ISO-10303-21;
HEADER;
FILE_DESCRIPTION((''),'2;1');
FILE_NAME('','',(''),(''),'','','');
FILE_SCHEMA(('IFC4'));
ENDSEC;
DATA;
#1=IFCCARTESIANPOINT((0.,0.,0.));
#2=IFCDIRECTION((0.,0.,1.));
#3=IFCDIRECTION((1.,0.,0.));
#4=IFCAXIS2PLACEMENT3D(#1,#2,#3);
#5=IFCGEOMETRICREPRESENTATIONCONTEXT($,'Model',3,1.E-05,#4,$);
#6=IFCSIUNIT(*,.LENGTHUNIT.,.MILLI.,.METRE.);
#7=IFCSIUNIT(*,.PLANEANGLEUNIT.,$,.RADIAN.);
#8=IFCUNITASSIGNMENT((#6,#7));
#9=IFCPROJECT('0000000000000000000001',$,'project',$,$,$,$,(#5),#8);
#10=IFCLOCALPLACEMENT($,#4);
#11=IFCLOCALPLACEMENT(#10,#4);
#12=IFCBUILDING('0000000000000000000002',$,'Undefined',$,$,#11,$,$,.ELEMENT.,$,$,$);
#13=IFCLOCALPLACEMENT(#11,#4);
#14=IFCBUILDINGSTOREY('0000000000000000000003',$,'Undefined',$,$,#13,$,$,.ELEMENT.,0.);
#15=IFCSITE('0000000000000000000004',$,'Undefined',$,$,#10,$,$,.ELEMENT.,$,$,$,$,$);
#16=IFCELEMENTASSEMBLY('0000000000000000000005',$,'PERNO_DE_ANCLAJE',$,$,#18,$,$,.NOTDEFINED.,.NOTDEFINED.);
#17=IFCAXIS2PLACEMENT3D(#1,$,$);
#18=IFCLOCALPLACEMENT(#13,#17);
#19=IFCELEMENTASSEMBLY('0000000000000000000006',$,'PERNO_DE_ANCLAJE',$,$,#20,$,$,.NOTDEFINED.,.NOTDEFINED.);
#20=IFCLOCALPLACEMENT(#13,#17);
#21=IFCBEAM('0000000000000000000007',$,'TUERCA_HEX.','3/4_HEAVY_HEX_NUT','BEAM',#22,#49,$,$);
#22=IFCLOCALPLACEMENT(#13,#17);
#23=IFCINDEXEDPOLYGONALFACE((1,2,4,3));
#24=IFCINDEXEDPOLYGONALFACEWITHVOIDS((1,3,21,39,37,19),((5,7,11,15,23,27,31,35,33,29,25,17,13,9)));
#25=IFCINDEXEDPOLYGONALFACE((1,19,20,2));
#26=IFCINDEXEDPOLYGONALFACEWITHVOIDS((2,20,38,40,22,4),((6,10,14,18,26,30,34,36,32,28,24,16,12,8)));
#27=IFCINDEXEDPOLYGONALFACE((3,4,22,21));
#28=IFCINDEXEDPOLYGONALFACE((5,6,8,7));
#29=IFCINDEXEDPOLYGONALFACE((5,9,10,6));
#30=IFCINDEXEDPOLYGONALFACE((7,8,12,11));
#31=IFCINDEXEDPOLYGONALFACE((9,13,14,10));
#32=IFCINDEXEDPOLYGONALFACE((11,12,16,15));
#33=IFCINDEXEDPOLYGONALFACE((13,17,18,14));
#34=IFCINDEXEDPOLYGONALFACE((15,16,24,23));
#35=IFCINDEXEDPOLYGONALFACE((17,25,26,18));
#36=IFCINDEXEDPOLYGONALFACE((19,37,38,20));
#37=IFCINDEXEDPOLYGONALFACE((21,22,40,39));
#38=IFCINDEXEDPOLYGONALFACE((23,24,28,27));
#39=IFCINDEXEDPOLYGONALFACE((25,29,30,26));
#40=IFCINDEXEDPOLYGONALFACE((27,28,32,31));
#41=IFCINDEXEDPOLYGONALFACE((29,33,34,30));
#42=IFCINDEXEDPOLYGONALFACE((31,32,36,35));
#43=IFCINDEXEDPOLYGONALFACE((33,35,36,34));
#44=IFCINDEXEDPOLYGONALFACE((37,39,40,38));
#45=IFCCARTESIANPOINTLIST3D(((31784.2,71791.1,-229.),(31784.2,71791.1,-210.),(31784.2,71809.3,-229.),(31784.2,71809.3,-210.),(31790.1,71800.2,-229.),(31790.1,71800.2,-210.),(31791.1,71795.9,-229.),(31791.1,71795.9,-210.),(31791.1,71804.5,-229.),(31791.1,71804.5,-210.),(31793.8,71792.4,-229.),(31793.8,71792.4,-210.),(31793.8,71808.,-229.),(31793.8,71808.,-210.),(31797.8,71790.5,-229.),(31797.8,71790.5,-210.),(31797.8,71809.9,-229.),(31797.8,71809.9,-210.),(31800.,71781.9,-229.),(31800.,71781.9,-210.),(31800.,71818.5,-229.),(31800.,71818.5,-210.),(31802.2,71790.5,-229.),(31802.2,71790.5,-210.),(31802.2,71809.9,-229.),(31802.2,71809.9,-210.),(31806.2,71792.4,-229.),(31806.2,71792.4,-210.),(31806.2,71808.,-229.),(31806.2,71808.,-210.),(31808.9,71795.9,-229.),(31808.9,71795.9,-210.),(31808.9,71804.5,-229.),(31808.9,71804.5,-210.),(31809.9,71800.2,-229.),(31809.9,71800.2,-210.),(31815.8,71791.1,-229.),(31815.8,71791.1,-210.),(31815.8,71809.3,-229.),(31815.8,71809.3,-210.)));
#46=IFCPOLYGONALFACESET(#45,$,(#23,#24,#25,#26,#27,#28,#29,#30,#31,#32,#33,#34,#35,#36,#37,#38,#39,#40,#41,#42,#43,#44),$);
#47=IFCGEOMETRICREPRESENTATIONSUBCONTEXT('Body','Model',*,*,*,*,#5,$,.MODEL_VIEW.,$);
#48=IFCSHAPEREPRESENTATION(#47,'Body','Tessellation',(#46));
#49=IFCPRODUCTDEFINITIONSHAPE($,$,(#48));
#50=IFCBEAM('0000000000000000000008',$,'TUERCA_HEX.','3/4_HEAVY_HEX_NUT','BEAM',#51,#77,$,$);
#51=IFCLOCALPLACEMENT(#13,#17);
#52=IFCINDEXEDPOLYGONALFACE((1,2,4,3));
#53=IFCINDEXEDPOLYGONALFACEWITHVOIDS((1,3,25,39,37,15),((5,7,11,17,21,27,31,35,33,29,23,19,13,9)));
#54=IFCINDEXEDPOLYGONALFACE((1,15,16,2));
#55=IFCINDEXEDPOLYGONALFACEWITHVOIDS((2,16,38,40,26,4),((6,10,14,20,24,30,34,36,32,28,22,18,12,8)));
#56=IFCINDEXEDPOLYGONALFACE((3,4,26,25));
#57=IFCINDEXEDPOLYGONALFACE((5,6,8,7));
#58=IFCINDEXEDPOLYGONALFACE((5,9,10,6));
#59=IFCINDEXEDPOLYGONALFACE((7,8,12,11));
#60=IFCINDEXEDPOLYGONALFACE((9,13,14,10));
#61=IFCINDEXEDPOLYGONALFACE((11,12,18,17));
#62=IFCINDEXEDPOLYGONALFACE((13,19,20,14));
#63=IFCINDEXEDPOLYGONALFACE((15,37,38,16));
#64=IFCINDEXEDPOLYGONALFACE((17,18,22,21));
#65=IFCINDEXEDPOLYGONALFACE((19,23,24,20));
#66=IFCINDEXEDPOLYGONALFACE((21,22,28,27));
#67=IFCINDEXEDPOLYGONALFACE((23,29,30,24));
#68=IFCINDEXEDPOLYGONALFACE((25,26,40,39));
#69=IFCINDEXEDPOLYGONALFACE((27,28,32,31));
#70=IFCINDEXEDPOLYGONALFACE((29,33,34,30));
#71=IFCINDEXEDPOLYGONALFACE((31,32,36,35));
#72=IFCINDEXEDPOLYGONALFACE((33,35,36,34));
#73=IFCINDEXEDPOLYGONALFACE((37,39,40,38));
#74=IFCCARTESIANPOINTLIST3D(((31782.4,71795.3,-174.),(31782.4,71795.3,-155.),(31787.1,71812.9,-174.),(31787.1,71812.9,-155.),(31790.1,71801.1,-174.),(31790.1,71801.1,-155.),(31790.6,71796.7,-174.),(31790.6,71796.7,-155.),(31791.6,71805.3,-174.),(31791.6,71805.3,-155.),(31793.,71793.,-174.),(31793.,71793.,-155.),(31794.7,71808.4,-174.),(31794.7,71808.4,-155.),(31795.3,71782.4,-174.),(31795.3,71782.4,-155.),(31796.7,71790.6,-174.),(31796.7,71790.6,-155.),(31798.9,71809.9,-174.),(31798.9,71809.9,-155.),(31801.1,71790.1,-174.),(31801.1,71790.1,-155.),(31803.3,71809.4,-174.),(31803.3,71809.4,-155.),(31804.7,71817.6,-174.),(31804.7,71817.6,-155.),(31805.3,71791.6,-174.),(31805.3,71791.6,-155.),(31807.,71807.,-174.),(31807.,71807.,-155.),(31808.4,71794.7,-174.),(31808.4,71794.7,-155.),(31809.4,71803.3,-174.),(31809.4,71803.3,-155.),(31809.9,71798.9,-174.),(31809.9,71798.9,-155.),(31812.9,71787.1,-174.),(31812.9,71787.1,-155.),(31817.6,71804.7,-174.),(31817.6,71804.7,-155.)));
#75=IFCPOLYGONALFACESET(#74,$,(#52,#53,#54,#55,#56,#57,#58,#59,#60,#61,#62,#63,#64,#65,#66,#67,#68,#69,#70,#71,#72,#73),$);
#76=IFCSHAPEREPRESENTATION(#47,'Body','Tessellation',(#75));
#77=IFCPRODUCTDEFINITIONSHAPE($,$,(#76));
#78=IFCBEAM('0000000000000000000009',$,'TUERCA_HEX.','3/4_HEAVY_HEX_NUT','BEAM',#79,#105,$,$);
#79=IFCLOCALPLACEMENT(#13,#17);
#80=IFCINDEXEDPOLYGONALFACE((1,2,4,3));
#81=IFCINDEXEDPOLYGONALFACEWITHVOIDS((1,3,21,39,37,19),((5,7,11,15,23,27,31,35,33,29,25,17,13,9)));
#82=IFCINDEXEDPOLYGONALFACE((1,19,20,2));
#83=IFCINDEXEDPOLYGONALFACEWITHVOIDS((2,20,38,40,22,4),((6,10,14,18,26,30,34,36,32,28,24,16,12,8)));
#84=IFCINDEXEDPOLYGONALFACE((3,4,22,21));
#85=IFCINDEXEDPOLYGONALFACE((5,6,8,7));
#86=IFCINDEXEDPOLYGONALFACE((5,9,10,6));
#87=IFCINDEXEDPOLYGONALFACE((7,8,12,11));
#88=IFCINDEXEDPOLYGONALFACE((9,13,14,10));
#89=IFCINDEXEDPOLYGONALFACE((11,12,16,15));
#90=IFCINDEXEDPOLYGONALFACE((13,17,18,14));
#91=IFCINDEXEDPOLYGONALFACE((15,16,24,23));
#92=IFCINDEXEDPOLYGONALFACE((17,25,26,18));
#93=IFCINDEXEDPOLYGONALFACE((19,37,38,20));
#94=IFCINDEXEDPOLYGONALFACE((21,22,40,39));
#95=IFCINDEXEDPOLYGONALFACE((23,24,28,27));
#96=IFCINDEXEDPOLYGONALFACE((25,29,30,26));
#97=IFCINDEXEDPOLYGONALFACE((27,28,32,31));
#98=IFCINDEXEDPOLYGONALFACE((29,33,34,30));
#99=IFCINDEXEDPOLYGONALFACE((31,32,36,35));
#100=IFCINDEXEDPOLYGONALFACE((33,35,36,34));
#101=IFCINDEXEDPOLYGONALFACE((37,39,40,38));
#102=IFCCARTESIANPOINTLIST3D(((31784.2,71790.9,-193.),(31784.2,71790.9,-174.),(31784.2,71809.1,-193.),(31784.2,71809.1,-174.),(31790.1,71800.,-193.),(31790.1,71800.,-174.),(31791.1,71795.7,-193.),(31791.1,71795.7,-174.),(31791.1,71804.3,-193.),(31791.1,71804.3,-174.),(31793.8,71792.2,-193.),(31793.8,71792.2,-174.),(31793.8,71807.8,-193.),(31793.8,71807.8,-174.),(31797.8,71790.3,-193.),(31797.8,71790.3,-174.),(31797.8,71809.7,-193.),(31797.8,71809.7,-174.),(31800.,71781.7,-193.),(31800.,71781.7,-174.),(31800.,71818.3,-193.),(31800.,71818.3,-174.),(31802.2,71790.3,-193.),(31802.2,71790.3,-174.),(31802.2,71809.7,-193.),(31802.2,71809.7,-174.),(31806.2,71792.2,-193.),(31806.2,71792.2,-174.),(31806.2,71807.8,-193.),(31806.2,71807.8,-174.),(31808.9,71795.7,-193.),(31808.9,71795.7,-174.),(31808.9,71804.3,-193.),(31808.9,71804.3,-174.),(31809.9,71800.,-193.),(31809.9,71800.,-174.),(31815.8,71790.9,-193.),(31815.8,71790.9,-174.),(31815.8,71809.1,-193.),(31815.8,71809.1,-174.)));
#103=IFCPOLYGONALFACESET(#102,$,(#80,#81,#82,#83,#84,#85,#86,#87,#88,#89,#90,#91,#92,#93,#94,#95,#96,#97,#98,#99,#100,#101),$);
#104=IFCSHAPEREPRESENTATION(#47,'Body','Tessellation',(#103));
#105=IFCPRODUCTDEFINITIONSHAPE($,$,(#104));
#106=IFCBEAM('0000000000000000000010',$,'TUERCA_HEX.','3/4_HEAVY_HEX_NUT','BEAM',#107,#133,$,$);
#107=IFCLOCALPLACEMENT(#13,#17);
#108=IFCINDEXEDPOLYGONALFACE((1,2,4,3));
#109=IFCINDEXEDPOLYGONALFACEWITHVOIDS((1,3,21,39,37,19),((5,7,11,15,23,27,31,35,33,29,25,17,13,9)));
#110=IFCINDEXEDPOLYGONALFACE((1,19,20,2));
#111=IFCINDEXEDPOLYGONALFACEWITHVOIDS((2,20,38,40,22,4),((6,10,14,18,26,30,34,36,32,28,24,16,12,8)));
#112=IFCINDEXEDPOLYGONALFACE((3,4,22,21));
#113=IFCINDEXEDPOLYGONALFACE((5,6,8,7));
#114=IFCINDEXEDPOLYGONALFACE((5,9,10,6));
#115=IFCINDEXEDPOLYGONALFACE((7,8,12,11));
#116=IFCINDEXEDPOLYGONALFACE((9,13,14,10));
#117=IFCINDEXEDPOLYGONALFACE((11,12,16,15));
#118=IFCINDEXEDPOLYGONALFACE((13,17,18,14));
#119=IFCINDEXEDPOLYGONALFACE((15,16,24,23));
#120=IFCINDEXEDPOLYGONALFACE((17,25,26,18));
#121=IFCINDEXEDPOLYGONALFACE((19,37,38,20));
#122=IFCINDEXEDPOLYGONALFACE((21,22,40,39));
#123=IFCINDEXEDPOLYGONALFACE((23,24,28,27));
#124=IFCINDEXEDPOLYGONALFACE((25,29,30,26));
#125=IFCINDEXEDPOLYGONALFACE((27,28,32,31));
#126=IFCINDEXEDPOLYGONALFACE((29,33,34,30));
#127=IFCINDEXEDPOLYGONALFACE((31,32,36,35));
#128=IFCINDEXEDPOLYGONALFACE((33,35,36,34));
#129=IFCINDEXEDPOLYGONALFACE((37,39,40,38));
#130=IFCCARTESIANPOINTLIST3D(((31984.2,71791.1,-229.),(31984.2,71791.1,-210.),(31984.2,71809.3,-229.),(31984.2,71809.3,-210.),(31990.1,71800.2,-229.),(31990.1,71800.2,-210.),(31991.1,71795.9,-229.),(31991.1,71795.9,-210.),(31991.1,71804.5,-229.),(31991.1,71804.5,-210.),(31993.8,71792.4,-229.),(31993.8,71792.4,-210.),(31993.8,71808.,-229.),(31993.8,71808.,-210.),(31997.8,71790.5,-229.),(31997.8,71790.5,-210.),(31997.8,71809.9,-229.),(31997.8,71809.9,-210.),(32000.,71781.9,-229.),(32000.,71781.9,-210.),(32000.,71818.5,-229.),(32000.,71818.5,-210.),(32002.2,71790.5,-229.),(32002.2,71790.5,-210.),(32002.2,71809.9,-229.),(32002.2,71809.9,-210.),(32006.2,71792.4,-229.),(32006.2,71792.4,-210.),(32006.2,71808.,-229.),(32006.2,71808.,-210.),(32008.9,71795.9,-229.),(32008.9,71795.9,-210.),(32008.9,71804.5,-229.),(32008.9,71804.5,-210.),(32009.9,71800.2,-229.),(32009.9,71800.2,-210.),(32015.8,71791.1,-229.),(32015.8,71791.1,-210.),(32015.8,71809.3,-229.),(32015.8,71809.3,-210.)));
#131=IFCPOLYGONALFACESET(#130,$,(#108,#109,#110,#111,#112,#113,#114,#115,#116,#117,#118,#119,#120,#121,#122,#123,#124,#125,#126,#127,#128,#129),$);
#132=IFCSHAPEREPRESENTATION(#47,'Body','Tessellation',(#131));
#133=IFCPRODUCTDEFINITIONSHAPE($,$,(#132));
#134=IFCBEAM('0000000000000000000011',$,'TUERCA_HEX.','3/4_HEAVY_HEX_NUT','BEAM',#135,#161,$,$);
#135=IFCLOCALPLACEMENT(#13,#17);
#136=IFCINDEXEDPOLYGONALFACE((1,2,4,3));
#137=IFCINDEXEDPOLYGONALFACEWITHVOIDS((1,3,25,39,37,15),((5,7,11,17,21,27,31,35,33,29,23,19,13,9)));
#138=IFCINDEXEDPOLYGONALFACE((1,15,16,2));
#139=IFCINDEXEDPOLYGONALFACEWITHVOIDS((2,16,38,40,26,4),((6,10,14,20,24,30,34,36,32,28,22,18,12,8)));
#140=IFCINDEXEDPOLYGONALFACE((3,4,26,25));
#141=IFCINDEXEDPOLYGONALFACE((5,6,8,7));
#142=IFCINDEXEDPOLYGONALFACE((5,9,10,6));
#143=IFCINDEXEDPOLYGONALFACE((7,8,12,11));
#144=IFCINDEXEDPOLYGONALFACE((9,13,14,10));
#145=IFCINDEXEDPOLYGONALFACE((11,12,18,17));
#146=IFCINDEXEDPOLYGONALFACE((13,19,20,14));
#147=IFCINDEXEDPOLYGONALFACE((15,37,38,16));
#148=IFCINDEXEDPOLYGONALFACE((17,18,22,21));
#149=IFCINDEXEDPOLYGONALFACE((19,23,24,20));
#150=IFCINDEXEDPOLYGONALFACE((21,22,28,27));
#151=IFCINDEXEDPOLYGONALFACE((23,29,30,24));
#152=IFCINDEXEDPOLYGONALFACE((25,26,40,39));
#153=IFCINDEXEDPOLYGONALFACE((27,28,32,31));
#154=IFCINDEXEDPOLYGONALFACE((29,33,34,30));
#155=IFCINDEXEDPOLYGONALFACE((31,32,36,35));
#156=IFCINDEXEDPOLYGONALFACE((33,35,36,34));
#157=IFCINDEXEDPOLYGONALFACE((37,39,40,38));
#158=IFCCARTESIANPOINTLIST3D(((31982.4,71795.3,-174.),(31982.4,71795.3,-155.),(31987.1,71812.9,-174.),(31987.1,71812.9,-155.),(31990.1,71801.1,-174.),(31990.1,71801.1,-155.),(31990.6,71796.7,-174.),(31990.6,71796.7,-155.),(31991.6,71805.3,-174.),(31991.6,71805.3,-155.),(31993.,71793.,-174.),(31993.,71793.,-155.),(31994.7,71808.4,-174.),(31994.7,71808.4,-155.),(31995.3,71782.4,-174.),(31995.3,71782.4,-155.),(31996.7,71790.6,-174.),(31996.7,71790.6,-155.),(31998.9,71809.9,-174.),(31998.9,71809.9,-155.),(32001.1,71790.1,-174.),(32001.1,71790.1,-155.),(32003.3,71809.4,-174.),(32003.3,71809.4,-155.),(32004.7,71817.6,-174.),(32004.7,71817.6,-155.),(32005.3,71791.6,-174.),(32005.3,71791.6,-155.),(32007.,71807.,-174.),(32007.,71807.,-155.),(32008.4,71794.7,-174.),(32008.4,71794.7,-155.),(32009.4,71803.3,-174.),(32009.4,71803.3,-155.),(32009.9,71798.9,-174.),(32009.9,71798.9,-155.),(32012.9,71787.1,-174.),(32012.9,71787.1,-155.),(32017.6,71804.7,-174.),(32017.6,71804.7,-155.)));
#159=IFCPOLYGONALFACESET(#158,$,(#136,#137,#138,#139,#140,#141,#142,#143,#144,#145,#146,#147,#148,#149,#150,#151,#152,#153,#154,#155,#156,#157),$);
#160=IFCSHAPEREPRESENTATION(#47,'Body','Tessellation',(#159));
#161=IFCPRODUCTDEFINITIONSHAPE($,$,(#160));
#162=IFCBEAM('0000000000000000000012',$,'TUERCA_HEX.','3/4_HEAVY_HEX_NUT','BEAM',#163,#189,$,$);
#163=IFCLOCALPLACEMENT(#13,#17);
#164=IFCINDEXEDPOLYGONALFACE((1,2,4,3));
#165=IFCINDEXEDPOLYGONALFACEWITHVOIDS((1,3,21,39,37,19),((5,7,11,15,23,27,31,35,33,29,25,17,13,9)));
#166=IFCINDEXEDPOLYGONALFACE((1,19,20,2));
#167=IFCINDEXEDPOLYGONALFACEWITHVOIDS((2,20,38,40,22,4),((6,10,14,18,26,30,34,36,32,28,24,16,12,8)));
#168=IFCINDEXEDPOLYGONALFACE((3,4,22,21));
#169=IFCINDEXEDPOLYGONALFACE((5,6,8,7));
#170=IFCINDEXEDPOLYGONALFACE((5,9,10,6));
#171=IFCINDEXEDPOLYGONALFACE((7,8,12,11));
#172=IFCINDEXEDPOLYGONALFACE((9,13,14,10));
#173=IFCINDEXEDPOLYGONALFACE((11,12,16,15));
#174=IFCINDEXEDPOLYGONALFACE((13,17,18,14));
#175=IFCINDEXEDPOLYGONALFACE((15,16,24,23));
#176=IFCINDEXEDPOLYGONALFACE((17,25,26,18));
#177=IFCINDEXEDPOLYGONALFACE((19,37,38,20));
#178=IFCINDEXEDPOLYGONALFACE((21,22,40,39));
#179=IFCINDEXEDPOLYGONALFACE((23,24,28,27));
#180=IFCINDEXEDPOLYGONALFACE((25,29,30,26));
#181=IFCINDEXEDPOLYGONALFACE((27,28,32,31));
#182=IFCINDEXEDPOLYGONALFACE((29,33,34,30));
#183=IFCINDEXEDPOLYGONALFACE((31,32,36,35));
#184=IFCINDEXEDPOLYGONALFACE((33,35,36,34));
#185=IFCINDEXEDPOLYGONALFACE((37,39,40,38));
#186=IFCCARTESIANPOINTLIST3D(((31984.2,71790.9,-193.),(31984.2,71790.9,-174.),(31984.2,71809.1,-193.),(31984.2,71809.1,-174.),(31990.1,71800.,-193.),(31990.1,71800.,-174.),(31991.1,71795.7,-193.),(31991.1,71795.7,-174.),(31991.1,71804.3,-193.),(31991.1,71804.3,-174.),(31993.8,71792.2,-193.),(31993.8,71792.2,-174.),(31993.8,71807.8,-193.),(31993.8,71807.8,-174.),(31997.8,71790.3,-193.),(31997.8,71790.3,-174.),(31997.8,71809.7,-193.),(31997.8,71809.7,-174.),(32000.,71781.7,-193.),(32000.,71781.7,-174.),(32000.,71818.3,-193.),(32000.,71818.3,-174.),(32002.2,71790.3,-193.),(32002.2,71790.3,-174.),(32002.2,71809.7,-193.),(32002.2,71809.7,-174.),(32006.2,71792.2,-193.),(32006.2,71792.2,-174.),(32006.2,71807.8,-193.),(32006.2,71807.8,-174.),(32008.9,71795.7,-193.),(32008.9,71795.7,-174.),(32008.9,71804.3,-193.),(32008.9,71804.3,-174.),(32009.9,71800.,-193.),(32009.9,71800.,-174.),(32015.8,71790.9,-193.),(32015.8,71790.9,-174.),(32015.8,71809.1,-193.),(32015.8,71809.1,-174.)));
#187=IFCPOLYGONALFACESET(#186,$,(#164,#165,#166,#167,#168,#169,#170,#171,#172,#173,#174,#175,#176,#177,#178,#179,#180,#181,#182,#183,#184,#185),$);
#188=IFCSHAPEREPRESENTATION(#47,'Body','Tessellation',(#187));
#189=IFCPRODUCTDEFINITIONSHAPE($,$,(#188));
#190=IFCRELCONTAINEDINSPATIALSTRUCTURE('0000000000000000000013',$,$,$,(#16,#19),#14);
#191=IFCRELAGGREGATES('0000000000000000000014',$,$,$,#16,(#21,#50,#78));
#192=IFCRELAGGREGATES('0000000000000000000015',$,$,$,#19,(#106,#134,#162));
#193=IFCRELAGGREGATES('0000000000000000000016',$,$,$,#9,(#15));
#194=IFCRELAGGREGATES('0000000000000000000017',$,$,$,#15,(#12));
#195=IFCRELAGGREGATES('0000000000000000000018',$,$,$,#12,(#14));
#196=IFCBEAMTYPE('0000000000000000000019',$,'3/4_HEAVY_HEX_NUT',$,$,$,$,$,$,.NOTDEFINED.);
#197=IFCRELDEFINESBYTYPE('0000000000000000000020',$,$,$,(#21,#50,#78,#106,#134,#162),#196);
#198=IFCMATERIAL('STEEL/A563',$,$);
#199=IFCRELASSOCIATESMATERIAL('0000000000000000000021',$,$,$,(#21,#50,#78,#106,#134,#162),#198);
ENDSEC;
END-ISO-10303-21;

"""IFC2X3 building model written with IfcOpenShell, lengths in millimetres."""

from ifc_helpers import new_model, si_unit, frame, origin_with_axes, place, context, subcontext, project, spatial, polyline, outline, extrude, material, type_object, element, aggregate, save


model = new_model("IFC2X3")

# Units and contexts
model_context = context("Model", 3, precision=1e-05, world=origin_with_axes())
body_context = subcontext(model_context, "Body", "Model", "MODEL_VIEW")
ifc_project = project(units=[si_unit("LENGTHUNIT", "METRE", prefix="MILLI"), si_unit("PLANEANGLEUNIT", "RADIAN")], contexts=[model_context])

# Site, building, storey
site_placement = place(None, origin_with_axes())
site = spatial("IfcSite", under=ifc_project, at=site_placement, Name="Undefined", CompositionType="ELEMENT")
building_placement = place(site_placement, origin_with_axes())
building = spatial("IfcBuilding", under=site, at=building_placement, Name="Undefined", CompositionType="ELEMENT")
storey_placement = place(building_placement, origin_with_axes())
storey = spatial("IfcBuildingStorey", under=building, at=storey_placement, Name="Undefined", CompositionType="ELEMENT", Elevation=0.0)

# Element assemblies
assembly_1_placement = place(storey_placement, origin_with_axes())
assembly_1 = element("IfcElementAssembly", 1, at=assembly_1_placement, inside=storey, Name="PERNO_DE_ANCLAJE", AssemblyPlace="NOTDEFINED", PredefinedType="NOTDEFINED")
ifc_material_1 = material(Name="STEEL/A563")
assembly_2_placement = place(storey_placement, origin_with_axes())
assembly_2 = element("IfcElementAssembly", 2, at=assembly_2_placement, inside=storey, Name="PERNO_DE_ANCLAJE", AssemblyPlace="NOTDEFINED", PredefinedType="NOTDEFINED")

# Beams
beam_type_1 = type_object("IfcBeamType", Name="3/4_HEAVY_HEX_NUT", PredefinedType="NOTDEFINED")
beam_1_placement = place(assembly_1_placement, frame((31800.0, 71800.2, -210.0), z_axis=(1.0, 0.0, 0.0), x_axis=(0.0, 0.0, -1.0)))
beam_1 = element("IfcBeam", 3, at=beam_1_placement, type_object=beam_type_1, material=ifc_material_1, Name="TUERCA_HEX.", Description="3/4_HEAVY_HEX_NUT", ObjectType="BEAM", context=body_context, shape_type="SweptSolid", body=[
    extrude(outline(polyline([(-9.1, -15.8), (-18.3, 0.0), (-9.1, 15.8), (9.1, 15.8), (18.3, 0.0), (9.1, -15.8), (-9.1, -15.8)]), holes=[polyline([(7.8, 6.2), (4.3, 8.9), (0.0, 9.9), (-4.3, 8.9), (-7.8, 6.2), (-9.7, 2.2), (-9.7, -2.2), (-7.8, -6.2), (-4.3, -8.9), (0.0, -9.9), (4.3, -8.9), (7.8, -6.2), (9.7, -2.2), (9.7, 2.2), (7.8, 6.2)])]), frame((19.0, 0.0, 0.0), z_axis=(-1.0, 0.0, 0.0), x_axis=(0.0, -1.0, 0.0)), (0.0, 0.0, 1.0), 19.0),
])
beam_2_placement = place(assembly_1_placement, frame((31800.0, 71800.0, -155.0), z_axis=(0.707107, 0.707107, 0.0), x_axis=(0.0, 0.0, -1.0)))
beam_2 = element("IfcBeam", 4, at=beam_2_placement, type_object=beam_type_1, material=ifc_material_1, Name="TUERCA_HEX.", Description="3/4_HEAVY_HEX_NUT", ObjectType="BEAM", context=body_context, shape_type="SweptSolid", body=[
    extrude(outline(polyline([(-9.1, -15.8), (-18.3, 0.0), (-9.1, 15.8), (9.1, 15.8), (18.3, 0.0), (9.1, -15.8), (-9.1, -15.8)]), holes=[polyline([(7.8, 6.2), (4.3, 8.9), (0.0, 9.9), (-4.3, 8.9), (-7.8, 6.2), (-9.7, 2.2), (-9.7, -2.2), (-7.8, -6.2), (-4.3, -8.9), (0.0, -9.9), (4.3, -8.9), (7.8, -6.2), (9.7, -2.2), (9.7, 2.2), (7.8, 6.2)])]), frame((19.0, 0.0, 0.0), z_axis=(-1.0, 0.0, 0.0), x_axis=(0.0, -1.0, 0.0)), (0.0, 0.0, 1.0), 19.0),
])
beam_3_placement = place(assembly_1_placement, frame((31800.0, 71800.0, -174.0), z_axis=(1.0, 0.0, 0.0), x_axis=(0.0, 0.0, -1.0)))
beam_3 = element("IfcBeam", 5, at=beam_3_placement, type_object=beam_type_1, material=ifc_material_1, Name="TUERCA_HEX.", Description="3/4_HEAVY_HEX_NUT", ObjectType="BEAM", context=body_context, shape_type="SweptSolid", body=[
    extrude(outline(polyline([(-9.1, -15.8), (-18.3, 0.0), (-9.1, 15.8), (9.1, 15.8), (18.3, 0.0), (9.1, -15.8), (-9.1, -15.8)]), holes=[polyline([(7.8, 6.2), (4.3, 8.9), (0.0, 9.9), (-4.3, 8.9), (-7.8, 6.2), (-9.7, 2.2), (-9.7, -2.2), (-7.8, -6.2), (-4.3, -8.9), (0.0, -9.9), (4.3, -8.9), (7.8, -6.2), (9.7, -2.2), (9.7, 2.2), (7.8, 6.2)])]), frame((19.0, 0.0, 0.0), z_axis=(-1.0, 0.0, 0.0), x_axis=(0.0, -1.0, 0.0)), (0.0, 0.0, 1.0), 19.0),
])
aggregate(assembly_1, [beam_1, beam_2, beam_3])
beam_4_placement = place(assembly_2_placement, frame((32000.0, 71800.2, -210.0), z_axis=(1.0, 0.0, 0.0), x_axis=(0.0, 0.0, -1.0)))
beam_4 = element("IfcBeam", 6, at=beam_4_placement, type_object=beam_type_1, material=ifc_material_1, Name="TUERCA_HEX.", Description="3/4_HEAVY_HEX_NUT", ObjectType="BEAM", context=body_context, shape_type="SweptSolid", body=[
    extrude(outline(polyline([(-9.1, -15.8), (-18.3, 0.0), (-9.1, 15.8), (9.1, 15.8), (18.3, 0.0), (9.1, -15.8), (-9.1, -15.8)]), holes=[polyline([(7.8, 6.2), (4.3, 8.9), (0.0, 9.9), (-4.3, 8.9), (-7.8, 6.2), (-9.7, 2.2), (-9.7, -2.2), (-7.8, -6.2), (-4.3, -8.9), (0.0, -9.9), (4.3, -8.9), (7.8, -6.2), (9.7, -2.2), (9.7, 2.2), (7.8, 6.2)])]), frame((19.0, 0.0, 0.0), z_axis=(-1.0, 0.0, 0.0), x_axis=(0.0, -1.0, 0.0)), (0.0, 0.0, 1.0), 19.0),
])
beam_5_placement = place(assembly_2_placement, frame((32000.0, 71800.0, -155.0), z_axis=(0.707107, 0.707107, 0.0), x_axis=(0.0, 0.0, -1.0)))
beam_5 = element("IfcBeam", 7, at=beam_5_placement, type_object=beam_type_1, material=ifc_material_1, Name="TUERCA_HEX.", Description="3/4_HEAVY_HEX_NUT", ObjectType="BEAM", context=body_context, shape_type="SweptSolid", body=[
    extrude(outline(polyline([(-9.1, -15.8), (-18.3, 0.0), (-9.1, 15.8), (9.1, 15.8), (18.3, 0.0), (9.1, -15.8), (-9.1, -15.8)]), holes=[polyline([(7.8, 6.2), (4.3, 8.9), (0.0, 9.9), (-4.3, 8.9), (-7.8, 6.2), (-9.7, 2.2), (-9.7, -2.2), (-7.8, -6.2), (-4.3, -8.9), (0.0, -9.9), (4.3, -8.9), (7.8, -6.2), (9.7, -2.2), (9.7, 2.2), (7.8, 6.2)])]), frame((19.0, 0.0, 0.0), z_axis=(-1.0, 0.0, 0.0), x_axis=(0.0, -1.0, 0.0)), (0.0, 0.0, 1.0), 19.0),
])
beam_6_placement = place(assembly_2_placement, frame((32000.0, 71800.0, -174.0), z_axis=(1.0, 0.0, 0.0), x_axis=(0.0, 0.0, -1.0)))
beam_6 = element("IfcBeam", 8, at=beam_6_placement, type_object=beam_type_1, material=ifc_material_1, Name="TUERCA_HEX.", Description="3/4_HEAVY_HEX_NUT", ObjectType="BEAM", context=body_context, shape_type="SweptSolid", body=[
    extrude(outline(polyline([(-9.1, -15.8), (-18.3, 0.0), (-9.1, 15.8), (9.1, 15.8), (18.3, 0.0), (9.1, -15.8), (-9.1, -15.8)]), holes=[polyline([(7.8, 6.2), (4.3, 8.9), (0.0, 9.9), (-4.3, 8.9), (-7.8, 6.2), (-9.7, 2.2), (-9.7, -2.2), (-7.8, -6.2), (-4.3, -8.9), (0.0, -9.9), (4.3, -8.9), (7.8, -6.2), (9.7, -2.2), (9.7, 2.2), (7.8, 6.2)])]), frame((19.0, 0.0, 0.0), z_axis=(-1.0, 0.0, 0.0), x_axis=(0.0, -1.0, 0.0)), (0.0, 0.0, 1.0), 19.0),
])
aggregate(assembly_2, [beam_4, beam_5, beam_6])

save(model, "model.ifc")
